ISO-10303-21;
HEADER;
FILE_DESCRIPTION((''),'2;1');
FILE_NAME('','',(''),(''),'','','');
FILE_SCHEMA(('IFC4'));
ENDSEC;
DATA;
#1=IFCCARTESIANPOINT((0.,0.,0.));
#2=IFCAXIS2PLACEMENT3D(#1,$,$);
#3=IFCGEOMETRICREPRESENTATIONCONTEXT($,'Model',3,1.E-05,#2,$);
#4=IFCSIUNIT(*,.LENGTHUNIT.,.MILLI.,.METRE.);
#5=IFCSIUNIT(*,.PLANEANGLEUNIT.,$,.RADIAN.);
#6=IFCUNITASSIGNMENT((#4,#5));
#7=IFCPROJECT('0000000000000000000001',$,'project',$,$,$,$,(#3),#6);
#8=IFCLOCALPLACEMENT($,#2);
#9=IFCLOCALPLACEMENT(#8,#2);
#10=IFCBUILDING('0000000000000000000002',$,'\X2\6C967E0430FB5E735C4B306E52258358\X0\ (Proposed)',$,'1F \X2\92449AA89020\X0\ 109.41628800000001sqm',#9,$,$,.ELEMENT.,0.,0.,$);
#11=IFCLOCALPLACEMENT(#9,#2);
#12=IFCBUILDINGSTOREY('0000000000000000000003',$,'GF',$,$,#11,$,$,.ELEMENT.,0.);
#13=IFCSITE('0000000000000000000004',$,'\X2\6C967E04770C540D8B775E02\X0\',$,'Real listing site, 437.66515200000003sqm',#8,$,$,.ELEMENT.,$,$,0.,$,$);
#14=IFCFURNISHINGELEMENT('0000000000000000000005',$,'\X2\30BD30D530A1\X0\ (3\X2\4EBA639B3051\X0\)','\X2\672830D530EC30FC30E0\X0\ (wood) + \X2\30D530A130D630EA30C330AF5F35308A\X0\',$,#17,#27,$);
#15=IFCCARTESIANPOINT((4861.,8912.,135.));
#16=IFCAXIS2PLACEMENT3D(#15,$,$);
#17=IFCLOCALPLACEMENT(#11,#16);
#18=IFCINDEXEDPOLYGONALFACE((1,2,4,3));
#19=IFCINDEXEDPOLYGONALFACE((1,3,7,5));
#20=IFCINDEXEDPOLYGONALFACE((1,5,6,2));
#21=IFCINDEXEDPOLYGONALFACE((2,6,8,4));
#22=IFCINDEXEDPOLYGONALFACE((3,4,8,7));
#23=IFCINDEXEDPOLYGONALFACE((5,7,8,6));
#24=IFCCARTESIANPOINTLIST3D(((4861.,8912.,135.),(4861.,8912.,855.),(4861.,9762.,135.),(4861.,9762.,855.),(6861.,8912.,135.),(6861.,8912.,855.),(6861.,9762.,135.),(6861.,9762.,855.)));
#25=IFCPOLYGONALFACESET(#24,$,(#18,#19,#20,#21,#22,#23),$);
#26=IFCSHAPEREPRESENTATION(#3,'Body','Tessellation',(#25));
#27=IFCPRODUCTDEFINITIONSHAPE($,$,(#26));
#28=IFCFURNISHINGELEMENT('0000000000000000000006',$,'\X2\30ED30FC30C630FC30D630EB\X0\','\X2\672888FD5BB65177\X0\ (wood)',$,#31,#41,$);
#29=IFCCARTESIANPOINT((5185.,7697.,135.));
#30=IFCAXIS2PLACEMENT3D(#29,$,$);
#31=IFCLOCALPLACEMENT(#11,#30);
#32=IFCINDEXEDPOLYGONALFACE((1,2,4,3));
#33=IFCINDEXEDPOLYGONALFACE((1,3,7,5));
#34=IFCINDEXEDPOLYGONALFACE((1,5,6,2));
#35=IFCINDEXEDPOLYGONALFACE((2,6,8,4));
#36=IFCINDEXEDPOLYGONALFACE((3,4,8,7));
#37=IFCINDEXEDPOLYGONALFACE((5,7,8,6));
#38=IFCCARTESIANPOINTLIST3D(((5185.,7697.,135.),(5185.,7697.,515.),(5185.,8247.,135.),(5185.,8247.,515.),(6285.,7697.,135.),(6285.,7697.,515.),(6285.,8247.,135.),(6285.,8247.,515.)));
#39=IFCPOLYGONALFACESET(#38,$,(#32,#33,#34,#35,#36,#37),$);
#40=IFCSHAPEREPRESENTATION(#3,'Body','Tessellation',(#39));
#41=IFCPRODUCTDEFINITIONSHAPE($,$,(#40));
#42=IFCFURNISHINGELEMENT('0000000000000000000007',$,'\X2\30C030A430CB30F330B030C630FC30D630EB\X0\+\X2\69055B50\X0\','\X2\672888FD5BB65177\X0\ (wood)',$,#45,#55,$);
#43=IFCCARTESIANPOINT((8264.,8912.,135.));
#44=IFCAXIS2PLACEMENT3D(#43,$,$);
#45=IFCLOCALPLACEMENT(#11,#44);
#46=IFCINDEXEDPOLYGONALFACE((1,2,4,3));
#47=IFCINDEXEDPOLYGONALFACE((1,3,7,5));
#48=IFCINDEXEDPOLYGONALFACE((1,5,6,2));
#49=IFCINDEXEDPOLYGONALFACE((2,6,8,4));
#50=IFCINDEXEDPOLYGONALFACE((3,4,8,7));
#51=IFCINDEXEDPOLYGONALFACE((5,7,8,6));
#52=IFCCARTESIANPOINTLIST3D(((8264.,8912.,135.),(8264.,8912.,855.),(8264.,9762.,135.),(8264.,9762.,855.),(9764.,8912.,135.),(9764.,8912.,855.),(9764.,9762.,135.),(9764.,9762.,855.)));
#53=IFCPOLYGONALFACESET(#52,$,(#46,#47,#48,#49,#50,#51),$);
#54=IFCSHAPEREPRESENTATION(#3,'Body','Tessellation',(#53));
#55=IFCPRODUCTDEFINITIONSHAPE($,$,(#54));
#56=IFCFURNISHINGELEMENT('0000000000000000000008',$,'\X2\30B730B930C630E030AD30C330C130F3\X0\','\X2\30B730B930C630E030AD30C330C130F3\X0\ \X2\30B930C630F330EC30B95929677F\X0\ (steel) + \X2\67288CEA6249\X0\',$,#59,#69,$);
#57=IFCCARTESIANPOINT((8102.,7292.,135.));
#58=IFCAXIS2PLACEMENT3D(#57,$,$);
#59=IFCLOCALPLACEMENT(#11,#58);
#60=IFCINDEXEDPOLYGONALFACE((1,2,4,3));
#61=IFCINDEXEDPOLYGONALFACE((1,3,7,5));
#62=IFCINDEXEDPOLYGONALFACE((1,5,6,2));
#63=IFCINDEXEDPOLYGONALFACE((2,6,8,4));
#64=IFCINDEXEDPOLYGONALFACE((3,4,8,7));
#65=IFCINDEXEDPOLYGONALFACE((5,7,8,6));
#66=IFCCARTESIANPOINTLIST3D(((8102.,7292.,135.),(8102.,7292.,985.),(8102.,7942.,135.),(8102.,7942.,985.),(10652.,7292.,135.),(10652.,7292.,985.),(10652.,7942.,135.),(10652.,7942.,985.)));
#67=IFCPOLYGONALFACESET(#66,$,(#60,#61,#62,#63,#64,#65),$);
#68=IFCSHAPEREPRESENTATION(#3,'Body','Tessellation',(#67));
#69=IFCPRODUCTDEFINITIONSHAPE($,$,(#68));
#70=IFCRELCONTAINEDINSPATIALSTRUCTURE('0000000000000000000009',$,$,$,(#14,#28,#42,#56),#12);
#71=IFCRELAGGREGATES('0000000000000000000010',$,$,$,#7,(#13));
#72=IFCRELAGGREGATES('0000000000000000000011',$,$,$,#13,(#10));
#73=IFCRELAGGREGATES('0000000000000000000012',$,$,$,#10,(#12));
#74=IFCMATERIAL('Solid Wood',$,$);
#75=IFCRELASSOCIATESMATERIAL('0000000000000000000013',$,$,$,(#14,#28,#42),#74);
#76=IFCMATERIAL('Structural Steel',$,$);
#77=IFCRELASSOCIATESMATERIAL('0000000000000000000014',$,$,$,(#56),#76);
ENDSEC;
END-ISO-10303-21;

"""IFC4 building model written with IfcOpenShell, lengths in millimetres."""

from ifc_helpers import new_model, si_unit, frame, frame_2d, origin, place, context, project, spatial, rectangle, extrude, material, element, save


model = new_model("IFC4")

# Units and contexts
model_context = context("Model", 3, precision=1e-05, world=origin())
ifc_project = project(units=[si_unit("LENGTHUNIT", "METRE", prefix="MILLI"), si_unit("PLANEANGLEUNIT", "RADIAN")], contexts=[model_context])

# Site, building, storey
site_placement = place(None, origin())
site = spatial("IfcSite", under=ifc_project, at=site_placement, Name="沖縄県名護市", ObjectType="Real listing site, 437.66515200000003sqm", CompositionType="ELEMENT", RefElevation=0.0)
building_placement = place(site_placement, origin())
building = spatial("IfcBuilding", under=site, at=building_placement, Name="沖縄・平屋の別荘 (Proposed)", ObjectType="1F 鉄骨造 109.41628800000001sqm", CompositionType="ELEMENT", ElevationOfRefHeight=0.0, ElevationOfTerrain=0.0)
storey_placement = place(building_placement, origin())
storey = spatial("IfcBuildingStorey", under=building, at=storey_placement, Name="GF", CompositionType="ELEMENT", Elevation=0.0)

# Shared definitions
ifc_material_1 = material(Name="Solid Wood")

# Shared definitions
ifc_material_2 = material(Name="Structural Steel")

# Furnishing elements
furnishing_1_placement = place(storey_placement, frame((4861.0, 8912.0, 135.0)))
element("IfcFurnishingElement", 1, at=furnishing_1_placement, inside=storey, material=ifc_material_1, Name="ソファ (3人掛け)", Description="木フレーム (wood) + ファブリック張り", context=model_context, shape_type="SweptSolid", body=[
    extrude(rectangle(XDim=2000.0, YDim=850.0, at=frame_2d((1000.0, 425.0))), frame((4861.0, 8912.0, 135.0)), (0.0, 0.0, 1.0), 720.0),
])
furnishing_2_placement = place(storey_placement, frame((5185.0, 7697.0, 135.0)))
element("IfcFurnishingElement", 2, at=furnishing_2_placement, inside=storey, material=ifc_material_1, Name="ローテーブル", Description="木製家具 (wood)", context=model_context, shape_type="SweptSolid", body=[
    extrude(rectangle(XDim=1100.0, YDim=550.0, at=frame_2d((550.0, 275.0))), frame((5185.0, 7697.0, 135.0)), (0.0, 0.0, 1.0), 380.0),
])
furnishing_3_placement = place(storey_placement, frame((8264.0, 8912.0, 135.0)))
element("IfcFurnishingElement", 3, at=furnishing_3_placement, inside=storey, material=ifc_material_1, Name="ダイニングテーブル+椅子", Description="木製家具 (wood)", context=model_context, shape_type="SweptSolid", body=[
    extrude(rectangle(XDim=1500.0, YDim=850.0, at=frame_2d((750.0, 425.0))), frame((8264.0, 8912.0, 135.0)), (0.0, 0.0, 1.0), 720.0),
])
furnishing_4_placement = place(storey_placement, frame((8102.0, 7292.0, 135.0)))
element("IfcFurnishingElement", 4, at=furnishing_4_placement, inside=storey, material=ifc_material_2, Name="システムキッチン", Description="システムキッチン ステンレス天板 (steel) + 木質扉", context=model_context, shape_type="SweptSolid", body=[
    extrude(rectangle(XDim=2550.0, YDim=650.0, at=frame_2d((1275.0, 325.0))), frame((8102.0, 7292.0, 135.0)), (0.0, 0.0, 1.0), 850.0),
])

save(model, "model.ifc")
